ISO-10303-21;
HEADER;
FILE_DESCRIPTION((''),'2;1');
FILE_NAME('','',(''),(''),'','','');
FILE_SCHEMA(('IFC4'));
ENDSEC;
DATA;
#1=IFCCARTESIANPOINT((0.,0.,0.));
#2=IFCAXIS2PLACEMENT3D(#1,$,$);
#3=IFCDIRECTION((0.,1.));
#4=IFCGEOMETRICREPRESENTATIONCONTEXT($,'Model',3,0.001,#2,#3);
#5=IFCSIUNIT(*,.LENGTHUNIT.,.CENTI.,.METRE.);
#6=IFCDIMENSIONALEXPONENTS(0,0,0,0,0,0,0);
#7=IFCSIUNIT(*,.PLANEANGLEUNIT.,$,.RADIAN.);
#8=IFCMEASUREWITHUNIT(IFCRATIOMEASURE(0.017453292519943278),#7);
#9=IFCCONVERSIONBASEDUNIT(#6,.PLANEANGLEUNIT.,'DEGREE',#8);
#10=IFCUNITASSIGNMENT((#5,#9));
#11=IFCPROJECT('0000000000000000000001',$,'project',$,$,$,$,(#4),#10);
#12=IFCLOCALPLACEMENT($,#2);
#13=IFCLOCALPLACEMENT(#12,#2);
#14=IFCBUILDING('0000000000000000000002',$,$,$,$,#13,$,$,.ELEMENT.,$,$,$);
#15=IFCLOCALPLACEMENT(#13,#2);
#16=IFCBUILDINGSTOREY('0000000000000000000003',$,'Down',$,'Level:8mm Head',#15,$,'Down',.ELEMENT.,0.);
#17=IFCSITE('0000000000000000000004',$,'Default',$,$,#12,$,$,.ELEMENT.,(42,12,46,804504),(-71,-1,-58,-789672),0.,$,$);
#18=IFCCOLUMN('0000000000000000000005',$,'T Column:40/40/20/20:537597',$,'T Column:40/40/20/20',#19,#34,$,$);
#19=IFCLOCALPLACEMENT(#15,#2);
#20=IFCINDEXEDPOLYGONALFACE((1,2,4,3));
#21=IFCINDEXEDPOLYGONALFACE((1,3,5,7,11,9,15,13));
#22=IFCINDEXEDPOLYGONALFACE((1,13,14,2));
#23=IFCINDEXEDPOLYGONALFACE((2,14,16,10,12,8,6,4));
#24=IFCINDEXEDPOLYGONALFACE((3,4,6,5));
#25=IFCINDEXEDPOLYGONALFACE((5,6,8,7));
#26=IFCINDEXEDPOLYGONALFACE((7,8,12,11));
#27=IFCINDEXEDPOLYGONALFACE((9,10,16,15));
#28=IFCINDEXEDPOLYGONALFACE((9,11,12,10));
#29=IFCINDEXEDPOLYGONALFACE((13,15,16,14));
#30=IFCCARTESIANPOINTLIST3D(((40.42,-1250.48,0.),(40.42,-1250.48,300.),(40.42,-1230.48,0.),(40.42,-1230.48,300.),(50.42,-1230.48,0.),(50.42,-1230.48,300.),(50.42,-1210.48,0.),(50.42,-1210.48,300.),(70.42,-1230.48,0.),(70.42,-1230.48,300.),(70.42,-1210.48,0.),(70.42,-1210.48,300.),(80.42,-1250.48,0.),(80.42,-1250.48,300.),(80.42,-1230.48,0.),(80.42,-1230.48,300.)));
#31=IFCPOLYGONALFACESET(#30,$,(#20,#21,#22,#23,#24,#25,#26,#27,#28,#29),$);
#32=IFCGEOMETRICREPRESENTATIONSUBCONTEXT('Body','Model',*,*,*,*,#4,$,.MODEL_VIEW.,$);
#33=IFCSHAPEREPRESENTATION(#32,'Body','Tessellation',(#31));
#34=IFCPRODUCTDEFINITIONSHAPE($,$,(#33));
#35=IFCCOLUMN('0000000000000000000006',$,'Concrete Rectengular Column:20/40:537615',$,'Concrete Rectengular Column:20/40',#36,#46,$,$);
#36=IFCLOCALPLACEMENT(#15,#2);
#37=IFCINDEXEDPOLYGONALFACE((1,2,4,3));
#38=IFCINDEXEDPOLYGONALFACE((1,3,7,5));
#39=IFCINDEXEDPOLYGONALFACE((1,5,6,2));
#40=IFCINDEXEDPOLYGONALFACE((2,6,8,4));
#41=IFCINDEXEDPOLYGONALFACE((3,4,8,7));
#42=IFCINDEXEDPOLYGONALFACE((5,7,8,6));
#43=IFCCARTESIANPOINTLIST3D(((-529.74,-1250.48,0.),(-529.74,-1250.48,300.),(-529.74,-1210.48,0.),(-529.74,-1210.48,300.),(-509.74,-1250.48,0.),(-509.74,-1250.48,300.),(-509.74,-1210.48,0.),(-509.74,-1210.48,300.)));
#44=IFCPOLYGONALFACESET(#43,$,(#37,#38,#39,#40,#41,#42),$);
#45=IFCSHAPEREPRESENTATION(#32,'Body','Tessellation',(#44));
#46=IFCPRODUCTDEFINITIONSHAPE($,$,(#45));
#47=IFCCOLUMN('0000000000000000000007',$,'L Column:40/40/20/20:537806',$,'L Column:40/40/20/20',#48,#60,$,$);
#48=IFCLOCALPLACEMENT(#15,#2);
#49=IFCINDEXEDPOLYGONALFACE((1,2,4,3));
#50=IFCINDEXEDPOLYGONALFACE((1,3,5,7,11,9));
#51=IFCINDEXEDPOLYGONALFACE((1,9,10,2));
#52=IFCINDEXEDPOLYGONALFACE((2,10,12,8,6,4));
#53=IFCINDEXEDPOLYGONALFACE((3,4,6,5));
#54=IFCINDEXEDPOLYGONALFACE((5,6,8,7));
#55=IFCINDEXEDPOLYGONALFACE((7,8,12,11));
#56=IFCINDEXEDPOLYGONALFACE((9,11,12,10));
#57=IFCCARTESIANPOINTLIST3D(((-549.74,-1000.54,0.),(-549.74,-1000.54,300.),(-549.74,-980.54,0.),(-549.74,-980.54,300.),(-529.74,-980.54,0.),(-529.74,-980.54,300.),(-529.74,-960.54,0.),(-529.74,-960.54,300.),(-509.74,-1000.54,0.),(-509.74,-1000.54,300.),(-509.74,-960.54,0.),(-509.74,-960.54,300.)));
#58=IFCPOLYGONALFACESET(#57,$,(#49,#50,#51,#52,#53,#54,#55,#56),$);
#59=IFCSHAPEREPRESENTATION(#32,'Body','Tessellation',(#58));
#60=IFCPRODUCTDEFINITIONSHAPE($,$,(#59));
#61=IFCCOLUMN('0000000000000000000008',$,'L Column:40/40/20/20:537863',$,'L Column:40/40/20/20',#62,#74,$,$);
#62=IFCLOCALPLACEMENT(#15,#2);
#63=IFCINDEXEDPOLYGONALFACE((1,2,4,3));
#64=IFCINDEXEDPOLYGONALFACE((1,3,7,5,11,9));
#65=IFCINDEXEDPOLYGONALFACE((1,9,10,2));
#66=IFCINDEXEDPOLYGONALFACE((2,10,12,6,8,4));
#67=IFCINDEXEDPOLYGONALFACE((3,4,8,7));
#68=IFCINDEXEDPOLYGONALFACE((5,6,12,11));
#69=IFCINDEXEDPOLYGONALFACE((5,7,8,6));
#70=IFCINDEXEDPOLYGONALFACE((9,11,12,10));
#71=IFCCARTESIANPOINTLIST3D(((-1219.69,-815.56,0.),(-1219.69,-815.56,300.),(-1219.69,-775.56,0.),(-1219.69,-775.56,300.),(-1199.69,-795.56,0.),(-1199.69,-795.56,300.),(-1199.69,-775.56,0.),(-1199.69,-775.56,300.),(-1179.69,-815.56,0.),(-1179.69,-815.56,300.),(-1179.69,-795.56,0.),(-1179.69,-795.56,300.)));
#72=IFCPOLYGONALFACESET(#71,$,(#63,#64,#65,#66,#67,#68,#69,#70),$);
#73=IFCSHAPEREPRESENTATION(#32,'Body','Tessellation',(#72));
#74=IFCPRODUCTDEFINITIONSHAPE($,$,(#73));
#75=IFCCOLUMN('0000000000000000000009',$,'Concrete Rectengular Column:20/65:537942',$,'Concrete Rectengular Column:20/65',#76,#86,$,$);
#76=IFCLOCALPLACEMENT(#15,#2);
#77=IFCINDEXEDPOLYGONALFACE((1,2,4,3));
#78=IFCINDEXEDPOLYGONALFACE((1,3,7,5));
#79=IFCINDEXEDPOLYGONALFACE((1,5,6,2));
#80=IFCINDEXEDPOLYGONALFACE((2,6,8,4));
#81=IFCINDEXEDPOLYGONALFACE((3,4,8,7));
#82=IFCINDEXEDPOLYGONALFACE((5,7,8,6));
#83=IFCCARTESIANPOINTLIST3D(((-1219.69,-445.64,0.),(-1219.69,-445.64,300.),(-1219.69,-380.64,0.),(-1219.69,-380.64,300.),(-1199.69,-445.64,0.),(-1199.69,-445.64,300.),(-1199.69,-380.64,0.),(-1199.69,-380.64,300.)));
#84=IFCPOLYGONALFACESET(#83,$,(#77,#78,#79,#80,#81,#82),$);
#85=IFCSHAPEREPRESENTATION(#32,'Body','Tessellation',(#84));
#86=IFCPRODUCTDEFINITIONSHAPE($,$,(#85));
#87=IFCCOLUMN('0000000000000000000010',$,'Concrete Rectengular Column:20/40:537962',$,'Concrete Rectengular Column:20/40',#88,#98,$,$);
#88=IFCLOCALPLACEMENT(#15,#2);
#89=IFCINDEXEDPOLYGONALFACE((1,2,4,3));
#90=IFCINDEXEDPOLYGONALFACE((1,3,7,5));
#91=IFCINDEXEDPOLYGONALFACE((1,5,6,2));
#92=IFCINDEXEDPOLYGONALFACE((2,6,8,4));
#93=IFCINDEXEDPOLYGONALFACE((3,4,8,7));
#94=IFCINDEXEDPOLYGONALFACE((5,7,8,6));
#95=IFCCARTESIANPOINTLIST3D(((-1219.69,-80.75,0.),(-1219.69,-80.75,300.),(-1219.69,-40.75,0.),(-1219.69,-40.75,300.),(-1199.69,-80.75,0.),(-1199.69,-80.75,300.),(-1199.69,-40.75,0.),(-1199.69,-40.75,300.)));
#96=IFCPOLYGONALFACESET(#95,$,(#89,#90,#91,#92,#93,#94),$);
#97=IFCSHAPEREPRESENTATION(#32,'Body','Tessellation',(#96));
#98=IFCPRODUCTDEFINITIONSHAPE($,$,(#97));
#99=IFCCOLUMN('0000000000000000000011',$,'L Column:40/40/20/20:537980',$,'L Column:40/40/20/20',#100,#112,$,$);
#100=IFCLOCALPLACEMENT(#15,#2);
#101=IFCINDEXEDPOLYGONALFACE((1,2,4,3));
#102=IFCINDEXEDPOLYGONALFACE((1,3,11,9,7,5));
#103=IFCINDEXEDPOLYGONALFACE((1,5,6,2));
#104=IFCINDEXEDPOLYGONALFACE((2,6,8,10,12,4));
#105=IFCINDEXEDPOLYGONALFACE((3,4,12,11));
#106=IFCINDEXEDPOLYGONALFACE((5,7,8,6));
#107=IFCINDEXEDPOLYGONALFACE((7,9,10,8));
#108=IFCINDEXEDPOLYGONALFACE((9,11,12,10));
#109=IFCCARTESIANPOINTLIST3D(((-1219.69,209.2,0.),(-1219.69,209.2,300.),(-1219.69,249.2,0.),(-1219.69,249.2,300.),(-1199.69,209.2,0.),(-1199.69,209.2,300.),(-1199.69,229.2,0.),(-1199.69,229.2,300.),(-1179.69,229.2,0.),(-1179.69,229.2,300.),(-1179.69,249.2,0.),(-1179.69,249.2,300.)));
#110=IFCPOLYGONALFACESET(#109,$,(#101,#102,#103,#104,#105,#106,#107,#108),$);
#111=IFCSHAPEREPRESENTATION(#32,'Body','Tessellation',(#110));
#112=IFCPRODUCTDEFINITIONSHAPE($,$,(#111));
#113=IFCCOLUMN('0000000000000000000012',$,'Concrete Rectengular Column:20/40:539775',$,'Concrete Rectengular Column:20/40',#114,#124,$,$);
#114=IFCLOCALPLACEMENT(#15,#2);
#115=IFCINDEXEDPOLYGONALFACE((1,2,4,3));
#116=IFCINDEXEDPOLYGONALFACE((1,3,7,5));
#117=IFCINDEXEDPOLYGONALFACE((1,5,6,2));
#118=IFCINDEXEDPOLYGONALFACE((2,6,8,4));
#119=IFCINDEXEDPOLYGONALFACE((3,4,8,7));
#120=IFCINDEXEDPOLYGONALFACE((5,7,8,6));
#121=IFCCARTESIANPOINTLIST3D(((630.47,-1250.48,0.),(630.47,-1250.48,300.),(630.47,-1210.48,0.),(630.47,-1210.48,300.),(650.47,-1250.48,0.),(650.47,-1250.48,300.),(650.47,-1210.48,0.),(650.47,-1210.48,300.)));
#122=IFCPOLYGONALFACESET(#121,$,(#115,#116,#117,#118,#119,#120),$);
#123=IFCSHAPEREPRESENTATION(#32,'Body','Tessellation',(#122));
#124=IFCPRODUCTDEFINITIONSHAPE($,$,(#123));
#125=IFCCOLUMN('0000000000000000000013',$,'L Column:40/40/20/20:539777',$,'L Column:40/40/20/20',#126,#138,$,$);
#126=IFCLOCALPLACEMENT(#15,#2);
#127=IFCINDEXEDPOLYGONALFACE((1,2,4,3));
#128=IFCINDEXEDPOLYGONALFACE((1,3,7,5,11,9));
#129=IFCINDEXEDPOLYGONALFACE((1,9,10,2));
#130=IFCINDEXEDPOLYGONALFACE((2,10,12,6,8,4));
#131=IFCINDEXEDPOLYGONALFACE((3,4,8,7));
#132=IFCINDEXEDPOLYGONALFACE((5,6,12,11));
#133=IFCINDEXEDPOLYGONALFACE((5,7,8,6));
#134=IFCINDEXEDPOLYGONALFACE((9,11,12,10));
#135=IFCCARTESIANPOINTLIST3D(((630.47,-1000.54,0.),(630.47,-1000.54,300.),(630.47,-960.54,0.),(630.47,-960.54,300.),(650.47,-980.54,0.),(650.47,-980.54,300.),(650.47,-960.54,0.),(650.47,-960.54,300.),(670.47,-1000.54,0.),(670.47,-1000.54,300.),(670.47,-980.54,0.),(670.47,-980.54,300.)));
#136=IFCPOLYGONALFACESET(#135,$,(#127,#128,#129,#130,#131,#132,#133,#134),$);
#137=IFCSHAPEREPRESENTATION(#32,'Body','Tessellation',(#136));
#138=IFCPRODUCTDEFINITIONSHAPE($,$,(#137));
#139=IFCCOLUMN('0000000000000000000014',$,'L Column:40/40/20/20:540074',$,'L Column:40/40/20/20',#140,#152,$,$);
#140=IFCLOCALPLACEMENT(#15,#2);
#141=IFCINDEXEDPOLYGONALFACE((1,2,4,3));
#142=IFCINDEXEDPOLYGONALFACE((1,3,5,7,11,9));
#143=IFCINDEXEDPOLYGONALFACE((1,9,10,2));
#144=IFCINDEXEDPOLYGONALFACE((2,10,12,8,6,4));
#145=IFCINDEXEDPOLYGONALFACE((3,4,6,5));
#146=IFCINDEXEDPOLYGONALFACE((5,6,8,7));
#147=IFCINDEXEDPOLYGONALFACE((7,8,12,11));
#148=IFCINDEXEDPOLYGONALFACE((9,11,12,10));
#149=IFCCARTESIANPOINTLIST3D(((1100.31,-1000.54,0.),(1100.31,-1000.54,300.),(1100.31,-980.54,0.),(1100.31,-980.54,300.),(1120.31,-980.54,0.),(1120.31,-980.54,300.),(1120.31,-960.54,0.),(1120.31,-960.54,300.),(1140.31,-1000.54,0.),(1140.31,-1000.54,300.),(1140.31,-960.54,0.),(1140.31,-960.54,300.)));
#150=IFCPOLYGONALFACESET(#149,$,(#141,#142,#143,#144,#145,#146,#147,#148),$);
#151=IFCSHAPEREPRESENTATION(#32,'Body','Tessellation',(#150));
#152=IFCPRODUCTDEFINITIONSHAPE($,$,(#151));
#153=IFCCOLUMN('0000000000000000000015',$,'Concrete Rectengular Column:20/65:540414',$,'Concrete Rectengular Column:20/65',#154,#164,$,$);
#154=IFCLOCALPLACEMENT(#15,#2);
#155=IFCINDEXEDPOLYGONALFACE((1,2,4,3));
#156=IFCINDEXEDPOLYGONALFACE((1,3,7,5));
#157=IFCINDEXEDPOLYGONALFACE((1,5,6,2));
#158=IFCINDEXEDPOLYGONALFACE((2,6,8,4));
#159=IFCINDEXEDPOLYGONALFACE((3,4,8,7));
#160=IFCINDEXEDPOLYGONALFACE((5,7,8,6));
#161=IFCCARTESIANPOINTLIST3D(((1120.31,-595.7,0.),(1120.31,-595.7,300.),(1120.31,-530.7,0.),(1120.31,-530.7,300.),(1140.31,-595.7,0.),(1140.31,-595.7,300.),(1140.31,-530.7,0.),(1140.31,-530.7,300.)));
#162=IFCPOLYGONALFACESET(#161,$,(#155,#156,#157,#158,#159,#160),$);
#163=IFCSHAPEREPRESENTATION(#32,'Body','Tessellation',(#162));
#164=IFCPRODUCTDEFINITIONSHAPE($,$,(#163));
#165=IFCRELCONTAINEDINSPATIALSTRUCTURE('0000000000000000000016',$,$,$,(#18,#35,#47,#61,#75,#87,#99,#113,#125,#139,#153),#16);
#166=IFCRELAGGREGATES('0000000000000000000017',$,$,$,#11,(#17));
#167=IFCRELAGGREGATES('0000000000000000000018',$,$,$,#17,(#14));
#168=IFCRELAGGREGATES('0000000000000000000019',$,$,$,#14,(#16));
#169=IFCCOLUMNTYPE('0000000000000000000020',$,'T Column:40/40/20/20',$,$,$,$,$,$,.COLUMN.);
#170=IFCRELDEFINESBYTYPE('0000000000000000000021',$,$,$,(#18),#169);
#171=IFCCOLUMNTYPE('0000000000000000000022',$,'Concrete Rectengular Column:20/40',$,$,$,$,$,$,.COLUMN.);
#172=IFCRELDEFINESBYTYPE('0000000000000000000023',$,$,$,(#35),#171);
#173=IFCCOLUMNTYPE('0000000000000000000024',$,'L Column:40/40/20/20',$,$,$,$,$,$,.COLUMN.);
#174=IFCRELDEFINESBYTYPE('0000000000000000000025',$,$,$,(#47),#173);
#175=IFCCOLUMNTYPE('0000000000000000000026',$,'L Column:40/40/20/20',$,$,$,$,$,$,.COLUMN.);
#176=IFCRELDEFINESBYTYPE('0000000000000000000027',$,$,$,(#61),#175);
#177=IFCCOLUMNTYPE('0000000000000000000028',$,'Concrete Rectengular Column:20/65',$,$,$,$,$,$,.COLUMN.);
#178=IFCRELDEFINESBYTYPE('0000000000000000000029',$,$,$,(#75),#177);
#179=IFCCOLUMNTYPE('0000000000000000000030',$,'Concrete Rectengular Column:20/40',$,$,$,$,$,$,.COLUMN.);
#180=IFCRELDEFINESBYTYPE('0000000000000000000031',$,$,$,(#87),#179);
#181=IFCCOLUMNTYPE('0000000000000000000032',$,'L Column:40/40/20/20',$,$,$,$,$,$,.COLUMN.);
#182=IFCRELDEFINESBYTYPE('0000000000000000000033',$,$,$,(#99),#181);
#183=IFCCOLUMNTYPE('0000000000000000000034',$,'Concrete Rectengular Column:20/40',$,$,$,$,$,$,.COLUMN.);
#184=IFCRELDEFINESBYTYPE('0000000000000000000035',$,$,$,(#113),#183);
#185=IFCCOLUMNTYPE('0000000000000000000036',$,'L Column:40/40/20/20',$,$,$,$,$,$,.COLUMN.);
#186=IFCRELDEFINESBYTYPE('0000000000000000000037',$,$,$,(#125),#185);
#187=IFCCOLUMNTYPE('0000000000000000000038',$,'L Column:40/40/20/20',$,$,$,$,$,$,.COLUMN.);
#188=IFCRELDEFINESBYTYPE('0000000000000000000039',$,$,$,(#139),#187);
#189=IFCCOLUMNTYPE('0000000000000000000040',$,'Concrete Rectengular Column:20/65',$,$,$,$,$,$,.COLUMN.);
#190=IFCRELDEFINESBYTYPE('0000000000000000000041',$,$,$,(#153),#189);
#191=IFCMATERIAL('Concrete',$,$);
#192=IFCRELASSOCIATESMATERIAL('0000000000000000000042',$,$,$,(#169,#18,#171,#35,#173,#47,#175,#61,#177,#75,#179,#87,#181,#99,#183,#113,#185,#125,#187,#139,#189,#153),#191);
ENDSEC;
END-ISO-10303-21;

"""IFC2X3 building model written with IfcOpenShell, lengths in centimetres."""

from ifc_helpers import new_model, entity, si_unit, converted_unit, direction, frame, frame_2d, origin, origin_2d_with_axis, place, context, subcontext, project, spatial, polyline, rectangle, outline, extrude, source, transform, mapped, material, type_object, type_shapes, element, save


model = new_model("IFC2X3")

# Units and contexts
model_context = context("Model", 3, precision=0.001, world=origin(), true_north=direction((0.0, 1.0)))
body_context = subcontext(model_context, "Body", "Model", "MODEL_VIEW")
ifc_project = project(units=[si_unit("LENGTHUNIT", "METRE", prefix="CENTI"), converted_unit("PLANEANGLEUNIT", "DEGREE", entity("IfcRatioMeasure", 0.017453292519943278), si_unit("PLANEANGLEUNIT", "RADIAN"), dimensions=[0, 0, 0, 0, 0, 0, 0])], contexts=[model_context])

# Site, building, storey
site_placement = place(None, origin())
site = spatial("IfcSite", under=ifc_project, at=site_placement, Name="Default", CompositionType="ELEMENT", RefLatitude=(42, 12, 46, 804504), RefLongitude=(-71, -1, -58, -789672), RefElevation=0.0)
building_placement = place(site_placement, origin())
building = spatial("IfcBuilding", under=site, at=building_placement, CompositionType="ELEMENT")
storey_placement = place(building_placement, origin())
storey = spatial("IfcBuildingStorey", under=building, at=storey_placement, Name="Down", ObjectType="Level:8mm Head", LongName="Down", CompositionType="ELEMENT", Elevation=0.0)

# Columns
ifc_material = material(Name="Concrete")
column_type_1 = type_object("IfcColumnType", Name="T Column:40/40/20/20", PredefinedType="COLUMN", material=ifc_material)
shared_shape_1 = source(origin(), body_context, "Body", "SweptSolid", [
    extrude(outline(polyline([(0.0, -20.0), (20.0, -20.0), (20.0, 20.0), (0.0, 20.0), (0.0, 10.0), (-20.0, 10.0), (-20.0, -10.0), (0.0, -10.0), (0.0, -20.0)])), frame((60.42, -1230.48, 0.0), z_axis=(0.0, 0.0, 1.0), x_axis=(0.0, -1.0, 0.0)), (0.0, 0.0, 1.0), 300.0),
])
type_shapes(column_type_1, [shared_shape_1])
column_1_placement = place(storey_placement, origin())
element("IfcColumn", 1, at=column_1_placement, inside=storey, type_object=column_type_1, material=ifc_material, Name="T Column:40/40/20/20:537597", ObjectType="T Column:40/40/20/20", context=body_context, shape_type="MappedRepresentation", body=[
    mapped(shared_shape_1, transform((0.0, 0.0, 0.0), scale=1.0)),
])
column_type_2 = type_object("IfcColumnType", Name="Concrete Rectengular Column:20/40", PredefinedType="COLUMN", material=ifc_material)
shared_shape_2 = source(origin(), body_context, "Body", "SweptSolid", [
    extrude(rectangle(XDim=40.0, YDim=20.0, at=origin_2d_with_axis()), frame((-519.74, -1230.48, 0.0), z_axis=(0.0, 0.0, 1.0), x_axis=(0.0, -1.0, 0.0)), (0.0, 0.0, 1.0), 300.0),
])
type_shapes(column_type_2, [shared_shape_2])
column_2_placement = place(storey_placement, origin())
element("IfcColumn", 2, at=column_2_placement, inside=storey, type_object=column_type_2, material=ifc_material, Name="Concrete Rectengular Column:20/40:537615", ObjectType="Concrete Rectengular Column:20/40", context=body_context, shape_type="MappedRepresentation", body=[
    mapped(shared_shape_2, transform((0.0, 0.0, 0.0), scale=1.0)),
])
column_type_3 = type_object("IfcColumnType", Name="L Column:40/40/20/20", PredefinedType="COLUMN", material=ifc_material)
shared_shape_3 = source(origin(), body_context, "Body", "SweptSolid", [
    extrude(outline(polyline([(0.0, -20.0), (20.0, -20.0), (20.0, 20.0), (-20.0, 20.0), (-20.0, 0.0), (0.0, 0.0), (0.0, -20.0)])), frame((-529.74, -980.54, 0.0), z_axis=(0.0, 0.0, 1.0), x_axis=(0.0, -1.0, 0.0)), (0.0, 0.0, 1.0), 300.0),
])
type_shapes(column_type_3, [shared_shape_3])
column_3_placement = place(storey_placement, origin())
element("IfcColumn", 3, at=column_3_placement, inside=storey, type_object=column_type_3, material=ifc_material, Name="L Column:40/40/20/20:537806", ObjectType="L Column:40/40/20/20", context=body_context, shape_type="MappedRepresentation", body=[
    mapped(shared_shape_3, transform((0.0, 0.0, 0.0), scale=1.0)),
])
column_type_4 = type_object("IfcColumnType", Name="L Column:40/40/20/20", PredefinedType="COLUMN", material=ifc_material)
shared_shape_4 = source(origin(), body_context, "Body", "SweptSolid", [
    extrude(outline(polyline([(-20.0, -20.0), (20.0, -20.0), (20.0, 20.0), (0.0, 20.0), (0.0, 0.0), (-20.0, 0.0), (-20.0, -20.0)])), frame((-1199.69, -795.56, 0.0), z_axis=(0.0, 0.0, 1.0), x_axis=(0.0, -1.0, 0.0)), (0.0, 0.0, 1.0), 300.0),
])
type_shapes(column_type_4, [shared_shape_4])
column_4_placement = place(storey_placement, origin())
element("IfcColumn", 4, at=column_4_placement, inside=storey, type_object=column_type_4, material=ifc_material, Name="L Column:40/40/20/20:537863", ObjectType="L Column:40/40/20/20", context=body_context, shape_type="MappedRepresentation", body=[
    mapped(shared_shape_4, transform((0.0, 0.0, 0.0), scale=1.0)),
])
column_type_5 = type_object("IfcColumnType", Name="Concrete Rectengular Column:20/65", PredefinedType="COLUMN", material=ifc_material)
shared_shape_5 = source(origin(), body_context, "Body", "SweptSolid", [
    extrude(rectangle(XDim=65.0, YDim=20.0, at=frame_2d((0.0, 0.0), x_axis=(1.0, 0.0))), frame((-1209.69, -413.14, 0.0), z_axis=(0.0, 0.0, 1.0), x_axis=(0.0, -1.0, 0.0)), (0.0, 0.0, 1.0), 300.0),
])
type_shapes(column_type_5, [shared_shape_5])
column_5_placement = place(storey_placement, origin())
element("IfcColumn", 5, at=column_5_placement, inside=storey, type_object=column_type_5, material=ifc_material, Name="Concrete Rectengular Column:20/65:537942", ObjectType="Concrete Rectengular Column:20/65", context=body_context, shape_type="MappedRepresentation", body=[
    mapped(shared_shape_5, transform((0.0, 0.0, 0.0), scale=1.0)),
])
column_type_6 = type_object("IfcColumnType", Name="Concrete Rectengular Column:20/40", PredefinedType="COLUMN", material=ifc_material)
shared_shape_6 = source(origin(), body_context, "Body", "SweptSolid", [
    extrude(rectangle(XDim=40.0, YDim=20.0, at=frame_2d((0.0, 0.0), x_axis=(1.0, 0.0))), frame((-1209.69, -60.75, 0.0), z_axis=(0.0, 0.0, 1.0), x_axis=(0.0, -1.0, 0.0)), (0.0, 0.0, 1.0), 300.0),
])
type_shapes(column_type_6, [shared_shape_6])
column_6_placement = place(storey_placement, origin())
element("IfcColumn", 6, at=column_6_placement, inside=storey, type_object=column_type_6, material=ifc_material, Name="Concrete Rectengular Column:20/40:537962", ObjectType="Concrete Rectengular Column:20/40", context=body_context, shape_type="MappedRepresentation", body=[
    mapped(shared_shape_6, transform((0.0, 0.0, 0.0), scale=1.0)),
])
column_type_7 = type_object("IfcColumnType", Name="L Column:40/40/20/20", PredefinedType="COLUMN", material=ifc_material)
shared_shape_7 = source(origin(), body_context, "Body", "SweptSolid", [
    extrude(outline(polyline([(-20.0, -20.0), (20.0, -20.0), (20.0, 0.0), (0.0, 0.0), (0.0, 20.0), (-20.0, 20.0), (-20.0, -20.0)])), frame((-1199.69, 229.2, 0.0), z_axis=(0.0, 0.0, 1.0), x_axis=(0.0, -1.0, 0.0)), (0.0, 0.0, 1.0), 300.0),
])
type_shapes(column_type_7, [shared_shape_7])
column_7_placement = place(storey_placement, origin())
element("IfcColumn", 7, at=column_7_placement, inside=storey, type_object=column_type_7, material=ifc_material, Name="L Column:40/40/20/20:537980", ObjectType="L Column:40/40/20/20", context=body_context, shape_type="MappedRepresentation", body=[
    mapped(shared_shape_7, transform((0.0, 0.0, 0.0), scale=1.0)),
])
column_type_8 = type_object("IfcColumnType", Name="Concrete Rectengular Column:20/40", PredefinedType="COLUMN", material=ifc_material)
shared_shape_8 = source(origin(), body_context, "Body", "SweptSolid", [
    extrude(rectangle(XDim=40.0, YDim=20.0, at=origin_2d_with_axis()), frame((640.47, -1230.48, 0.0), z_axis=(0.0, 0.0, 1.0), x_axis=(0.0, -1.0, 0.0)), (0.0, 0.0, 1.0), 300.0),
])
type_shapes(column_type_8, [shared_shape_8])
column_8_placement = place(storey_placement, origin())
element("IfcColumn", 8, at=column_8_placement, inside=storey, type_object=column_type_8, material=ifc_material, Name="Concrete Rectengular Column:20/40:539775", ObjectType="Concrete Rectengular Column:20/40", context=body_context, shape_type="MappedRepresentation", body=[
    mapped(shared_shape_8, transform((0.0, 0.0, 0.0), scale=1.0)),
])
column_type_9 = type_object("IfcColumnType", Name="L Column:40/40/20/20", PredefinedType="COLUMN", material=ifc_material)
shared_shape_9 = source(origin(), body_context, "Body", "SweptSolid", [
    extrude(outline(polyline([(-20.0, -20.0), (20.0, -20.0), (20.0, 20.0), (0.0, 20.0), (0.0, 0.0), (-20.0, 0.0), (-20.0, -20.0)])), frame((650.47, -980.54, 0.0), z_axis=(0.0, 0.0, 1.0), x_axis=(0.0, -1.0, 0.0)), (0.0, 0.0, 1.0), 300.0),
])
type_shapes(column_type_9, [shared_shape_9])
column_9_placement = place(storey_placement, origin())
element("IfcColumn", 9, at=column_9_placement, inside=storey, type_object=column_type_9, material=ifc_material, Name="L Column:40/40/20/20:539777", ObjectType="L Column:40/40/20/20", context=body_context, shape_type="MappedRepresentation", body=[
    mapped(shared_shape_9, transform((0.0, 0.0, 0.0), scale=1.0)),
])
column_type_10 = type_object("IfcColumnType", Name="L Column:40/40/20/20", PredefinedType="COLUMN", material=ifc_material)
shared_shape_10 = source(origin(), body_context, "Body", "SweptSolid", [
    extrude(outline(polyline([(0.0, -20.0), (20.0, -20.0), (20.0, 20.0), (-20.0, 20.0), (-20.0, 0.0), (0.0, 0.0), (0.0, -20.0)])), frame((1120.31, -980.54, 0.0), z_axis=(0.0, 0.0, 1.0), x_axis=(0.0, -1.0, 0.0)), (0.0, 0.0, 1.0), 300.0),
])
type_shapes(column_type_10, [shared_shape_10])
column_10_placement = place(storey_placement, origin())
element("IfcColumn", 10, at=column_10_placement, inside=storey, type_object=column_type_10, material=ifc_material, Name="L Column:40/40/20/20:540074", ObjectType="L Column:40/40/20/20", context=body_context, shape_type="MappedRepresentation", body=[
    mapped(shared_shape_10, transform((0.0, 0.0, 0.0), scale=1.0)),
])
column_type_11 = type_object("IfcColumnType", Name="Concrete Rectengular Column:20/65", PredefinedType="COLUMN", material=ifc_material)
shared_shape_11 = source(origin(), body_context, "Body", "SweptSolid", [
    extrude(rectangle(XDim=65.0, YDim=20.0, at=frame_2d((0.0, 0.0), x_axis=(1.0, 0.0))), frame((1130.31, -563.2, 0.0), z_axis=(0.0, 0.0, 1.0), x_axis=(0.0, -1.0, 0.0)), (0.0, 0.0, 1.0), 300.0),
])
type_shapes(column_type_11, [shared_shape_11])
column_11_placement = place(storey_placement, origin())
element("IfcColumn", 11, at=column_11_placement, inside=storey, type_object=column_type_11, material=ifc_material, Name="Concrete Rectengular Column:20/65:540414", ObjectType="Concrete Rectengular Column:20/65", context=body_context, shape_type="MappedRepresentation", body=[
    mapped(shared_shape_11, transform((0.0, 0.0, 0.0), scale=1.0)),
])

save(model, "model.ifc")
